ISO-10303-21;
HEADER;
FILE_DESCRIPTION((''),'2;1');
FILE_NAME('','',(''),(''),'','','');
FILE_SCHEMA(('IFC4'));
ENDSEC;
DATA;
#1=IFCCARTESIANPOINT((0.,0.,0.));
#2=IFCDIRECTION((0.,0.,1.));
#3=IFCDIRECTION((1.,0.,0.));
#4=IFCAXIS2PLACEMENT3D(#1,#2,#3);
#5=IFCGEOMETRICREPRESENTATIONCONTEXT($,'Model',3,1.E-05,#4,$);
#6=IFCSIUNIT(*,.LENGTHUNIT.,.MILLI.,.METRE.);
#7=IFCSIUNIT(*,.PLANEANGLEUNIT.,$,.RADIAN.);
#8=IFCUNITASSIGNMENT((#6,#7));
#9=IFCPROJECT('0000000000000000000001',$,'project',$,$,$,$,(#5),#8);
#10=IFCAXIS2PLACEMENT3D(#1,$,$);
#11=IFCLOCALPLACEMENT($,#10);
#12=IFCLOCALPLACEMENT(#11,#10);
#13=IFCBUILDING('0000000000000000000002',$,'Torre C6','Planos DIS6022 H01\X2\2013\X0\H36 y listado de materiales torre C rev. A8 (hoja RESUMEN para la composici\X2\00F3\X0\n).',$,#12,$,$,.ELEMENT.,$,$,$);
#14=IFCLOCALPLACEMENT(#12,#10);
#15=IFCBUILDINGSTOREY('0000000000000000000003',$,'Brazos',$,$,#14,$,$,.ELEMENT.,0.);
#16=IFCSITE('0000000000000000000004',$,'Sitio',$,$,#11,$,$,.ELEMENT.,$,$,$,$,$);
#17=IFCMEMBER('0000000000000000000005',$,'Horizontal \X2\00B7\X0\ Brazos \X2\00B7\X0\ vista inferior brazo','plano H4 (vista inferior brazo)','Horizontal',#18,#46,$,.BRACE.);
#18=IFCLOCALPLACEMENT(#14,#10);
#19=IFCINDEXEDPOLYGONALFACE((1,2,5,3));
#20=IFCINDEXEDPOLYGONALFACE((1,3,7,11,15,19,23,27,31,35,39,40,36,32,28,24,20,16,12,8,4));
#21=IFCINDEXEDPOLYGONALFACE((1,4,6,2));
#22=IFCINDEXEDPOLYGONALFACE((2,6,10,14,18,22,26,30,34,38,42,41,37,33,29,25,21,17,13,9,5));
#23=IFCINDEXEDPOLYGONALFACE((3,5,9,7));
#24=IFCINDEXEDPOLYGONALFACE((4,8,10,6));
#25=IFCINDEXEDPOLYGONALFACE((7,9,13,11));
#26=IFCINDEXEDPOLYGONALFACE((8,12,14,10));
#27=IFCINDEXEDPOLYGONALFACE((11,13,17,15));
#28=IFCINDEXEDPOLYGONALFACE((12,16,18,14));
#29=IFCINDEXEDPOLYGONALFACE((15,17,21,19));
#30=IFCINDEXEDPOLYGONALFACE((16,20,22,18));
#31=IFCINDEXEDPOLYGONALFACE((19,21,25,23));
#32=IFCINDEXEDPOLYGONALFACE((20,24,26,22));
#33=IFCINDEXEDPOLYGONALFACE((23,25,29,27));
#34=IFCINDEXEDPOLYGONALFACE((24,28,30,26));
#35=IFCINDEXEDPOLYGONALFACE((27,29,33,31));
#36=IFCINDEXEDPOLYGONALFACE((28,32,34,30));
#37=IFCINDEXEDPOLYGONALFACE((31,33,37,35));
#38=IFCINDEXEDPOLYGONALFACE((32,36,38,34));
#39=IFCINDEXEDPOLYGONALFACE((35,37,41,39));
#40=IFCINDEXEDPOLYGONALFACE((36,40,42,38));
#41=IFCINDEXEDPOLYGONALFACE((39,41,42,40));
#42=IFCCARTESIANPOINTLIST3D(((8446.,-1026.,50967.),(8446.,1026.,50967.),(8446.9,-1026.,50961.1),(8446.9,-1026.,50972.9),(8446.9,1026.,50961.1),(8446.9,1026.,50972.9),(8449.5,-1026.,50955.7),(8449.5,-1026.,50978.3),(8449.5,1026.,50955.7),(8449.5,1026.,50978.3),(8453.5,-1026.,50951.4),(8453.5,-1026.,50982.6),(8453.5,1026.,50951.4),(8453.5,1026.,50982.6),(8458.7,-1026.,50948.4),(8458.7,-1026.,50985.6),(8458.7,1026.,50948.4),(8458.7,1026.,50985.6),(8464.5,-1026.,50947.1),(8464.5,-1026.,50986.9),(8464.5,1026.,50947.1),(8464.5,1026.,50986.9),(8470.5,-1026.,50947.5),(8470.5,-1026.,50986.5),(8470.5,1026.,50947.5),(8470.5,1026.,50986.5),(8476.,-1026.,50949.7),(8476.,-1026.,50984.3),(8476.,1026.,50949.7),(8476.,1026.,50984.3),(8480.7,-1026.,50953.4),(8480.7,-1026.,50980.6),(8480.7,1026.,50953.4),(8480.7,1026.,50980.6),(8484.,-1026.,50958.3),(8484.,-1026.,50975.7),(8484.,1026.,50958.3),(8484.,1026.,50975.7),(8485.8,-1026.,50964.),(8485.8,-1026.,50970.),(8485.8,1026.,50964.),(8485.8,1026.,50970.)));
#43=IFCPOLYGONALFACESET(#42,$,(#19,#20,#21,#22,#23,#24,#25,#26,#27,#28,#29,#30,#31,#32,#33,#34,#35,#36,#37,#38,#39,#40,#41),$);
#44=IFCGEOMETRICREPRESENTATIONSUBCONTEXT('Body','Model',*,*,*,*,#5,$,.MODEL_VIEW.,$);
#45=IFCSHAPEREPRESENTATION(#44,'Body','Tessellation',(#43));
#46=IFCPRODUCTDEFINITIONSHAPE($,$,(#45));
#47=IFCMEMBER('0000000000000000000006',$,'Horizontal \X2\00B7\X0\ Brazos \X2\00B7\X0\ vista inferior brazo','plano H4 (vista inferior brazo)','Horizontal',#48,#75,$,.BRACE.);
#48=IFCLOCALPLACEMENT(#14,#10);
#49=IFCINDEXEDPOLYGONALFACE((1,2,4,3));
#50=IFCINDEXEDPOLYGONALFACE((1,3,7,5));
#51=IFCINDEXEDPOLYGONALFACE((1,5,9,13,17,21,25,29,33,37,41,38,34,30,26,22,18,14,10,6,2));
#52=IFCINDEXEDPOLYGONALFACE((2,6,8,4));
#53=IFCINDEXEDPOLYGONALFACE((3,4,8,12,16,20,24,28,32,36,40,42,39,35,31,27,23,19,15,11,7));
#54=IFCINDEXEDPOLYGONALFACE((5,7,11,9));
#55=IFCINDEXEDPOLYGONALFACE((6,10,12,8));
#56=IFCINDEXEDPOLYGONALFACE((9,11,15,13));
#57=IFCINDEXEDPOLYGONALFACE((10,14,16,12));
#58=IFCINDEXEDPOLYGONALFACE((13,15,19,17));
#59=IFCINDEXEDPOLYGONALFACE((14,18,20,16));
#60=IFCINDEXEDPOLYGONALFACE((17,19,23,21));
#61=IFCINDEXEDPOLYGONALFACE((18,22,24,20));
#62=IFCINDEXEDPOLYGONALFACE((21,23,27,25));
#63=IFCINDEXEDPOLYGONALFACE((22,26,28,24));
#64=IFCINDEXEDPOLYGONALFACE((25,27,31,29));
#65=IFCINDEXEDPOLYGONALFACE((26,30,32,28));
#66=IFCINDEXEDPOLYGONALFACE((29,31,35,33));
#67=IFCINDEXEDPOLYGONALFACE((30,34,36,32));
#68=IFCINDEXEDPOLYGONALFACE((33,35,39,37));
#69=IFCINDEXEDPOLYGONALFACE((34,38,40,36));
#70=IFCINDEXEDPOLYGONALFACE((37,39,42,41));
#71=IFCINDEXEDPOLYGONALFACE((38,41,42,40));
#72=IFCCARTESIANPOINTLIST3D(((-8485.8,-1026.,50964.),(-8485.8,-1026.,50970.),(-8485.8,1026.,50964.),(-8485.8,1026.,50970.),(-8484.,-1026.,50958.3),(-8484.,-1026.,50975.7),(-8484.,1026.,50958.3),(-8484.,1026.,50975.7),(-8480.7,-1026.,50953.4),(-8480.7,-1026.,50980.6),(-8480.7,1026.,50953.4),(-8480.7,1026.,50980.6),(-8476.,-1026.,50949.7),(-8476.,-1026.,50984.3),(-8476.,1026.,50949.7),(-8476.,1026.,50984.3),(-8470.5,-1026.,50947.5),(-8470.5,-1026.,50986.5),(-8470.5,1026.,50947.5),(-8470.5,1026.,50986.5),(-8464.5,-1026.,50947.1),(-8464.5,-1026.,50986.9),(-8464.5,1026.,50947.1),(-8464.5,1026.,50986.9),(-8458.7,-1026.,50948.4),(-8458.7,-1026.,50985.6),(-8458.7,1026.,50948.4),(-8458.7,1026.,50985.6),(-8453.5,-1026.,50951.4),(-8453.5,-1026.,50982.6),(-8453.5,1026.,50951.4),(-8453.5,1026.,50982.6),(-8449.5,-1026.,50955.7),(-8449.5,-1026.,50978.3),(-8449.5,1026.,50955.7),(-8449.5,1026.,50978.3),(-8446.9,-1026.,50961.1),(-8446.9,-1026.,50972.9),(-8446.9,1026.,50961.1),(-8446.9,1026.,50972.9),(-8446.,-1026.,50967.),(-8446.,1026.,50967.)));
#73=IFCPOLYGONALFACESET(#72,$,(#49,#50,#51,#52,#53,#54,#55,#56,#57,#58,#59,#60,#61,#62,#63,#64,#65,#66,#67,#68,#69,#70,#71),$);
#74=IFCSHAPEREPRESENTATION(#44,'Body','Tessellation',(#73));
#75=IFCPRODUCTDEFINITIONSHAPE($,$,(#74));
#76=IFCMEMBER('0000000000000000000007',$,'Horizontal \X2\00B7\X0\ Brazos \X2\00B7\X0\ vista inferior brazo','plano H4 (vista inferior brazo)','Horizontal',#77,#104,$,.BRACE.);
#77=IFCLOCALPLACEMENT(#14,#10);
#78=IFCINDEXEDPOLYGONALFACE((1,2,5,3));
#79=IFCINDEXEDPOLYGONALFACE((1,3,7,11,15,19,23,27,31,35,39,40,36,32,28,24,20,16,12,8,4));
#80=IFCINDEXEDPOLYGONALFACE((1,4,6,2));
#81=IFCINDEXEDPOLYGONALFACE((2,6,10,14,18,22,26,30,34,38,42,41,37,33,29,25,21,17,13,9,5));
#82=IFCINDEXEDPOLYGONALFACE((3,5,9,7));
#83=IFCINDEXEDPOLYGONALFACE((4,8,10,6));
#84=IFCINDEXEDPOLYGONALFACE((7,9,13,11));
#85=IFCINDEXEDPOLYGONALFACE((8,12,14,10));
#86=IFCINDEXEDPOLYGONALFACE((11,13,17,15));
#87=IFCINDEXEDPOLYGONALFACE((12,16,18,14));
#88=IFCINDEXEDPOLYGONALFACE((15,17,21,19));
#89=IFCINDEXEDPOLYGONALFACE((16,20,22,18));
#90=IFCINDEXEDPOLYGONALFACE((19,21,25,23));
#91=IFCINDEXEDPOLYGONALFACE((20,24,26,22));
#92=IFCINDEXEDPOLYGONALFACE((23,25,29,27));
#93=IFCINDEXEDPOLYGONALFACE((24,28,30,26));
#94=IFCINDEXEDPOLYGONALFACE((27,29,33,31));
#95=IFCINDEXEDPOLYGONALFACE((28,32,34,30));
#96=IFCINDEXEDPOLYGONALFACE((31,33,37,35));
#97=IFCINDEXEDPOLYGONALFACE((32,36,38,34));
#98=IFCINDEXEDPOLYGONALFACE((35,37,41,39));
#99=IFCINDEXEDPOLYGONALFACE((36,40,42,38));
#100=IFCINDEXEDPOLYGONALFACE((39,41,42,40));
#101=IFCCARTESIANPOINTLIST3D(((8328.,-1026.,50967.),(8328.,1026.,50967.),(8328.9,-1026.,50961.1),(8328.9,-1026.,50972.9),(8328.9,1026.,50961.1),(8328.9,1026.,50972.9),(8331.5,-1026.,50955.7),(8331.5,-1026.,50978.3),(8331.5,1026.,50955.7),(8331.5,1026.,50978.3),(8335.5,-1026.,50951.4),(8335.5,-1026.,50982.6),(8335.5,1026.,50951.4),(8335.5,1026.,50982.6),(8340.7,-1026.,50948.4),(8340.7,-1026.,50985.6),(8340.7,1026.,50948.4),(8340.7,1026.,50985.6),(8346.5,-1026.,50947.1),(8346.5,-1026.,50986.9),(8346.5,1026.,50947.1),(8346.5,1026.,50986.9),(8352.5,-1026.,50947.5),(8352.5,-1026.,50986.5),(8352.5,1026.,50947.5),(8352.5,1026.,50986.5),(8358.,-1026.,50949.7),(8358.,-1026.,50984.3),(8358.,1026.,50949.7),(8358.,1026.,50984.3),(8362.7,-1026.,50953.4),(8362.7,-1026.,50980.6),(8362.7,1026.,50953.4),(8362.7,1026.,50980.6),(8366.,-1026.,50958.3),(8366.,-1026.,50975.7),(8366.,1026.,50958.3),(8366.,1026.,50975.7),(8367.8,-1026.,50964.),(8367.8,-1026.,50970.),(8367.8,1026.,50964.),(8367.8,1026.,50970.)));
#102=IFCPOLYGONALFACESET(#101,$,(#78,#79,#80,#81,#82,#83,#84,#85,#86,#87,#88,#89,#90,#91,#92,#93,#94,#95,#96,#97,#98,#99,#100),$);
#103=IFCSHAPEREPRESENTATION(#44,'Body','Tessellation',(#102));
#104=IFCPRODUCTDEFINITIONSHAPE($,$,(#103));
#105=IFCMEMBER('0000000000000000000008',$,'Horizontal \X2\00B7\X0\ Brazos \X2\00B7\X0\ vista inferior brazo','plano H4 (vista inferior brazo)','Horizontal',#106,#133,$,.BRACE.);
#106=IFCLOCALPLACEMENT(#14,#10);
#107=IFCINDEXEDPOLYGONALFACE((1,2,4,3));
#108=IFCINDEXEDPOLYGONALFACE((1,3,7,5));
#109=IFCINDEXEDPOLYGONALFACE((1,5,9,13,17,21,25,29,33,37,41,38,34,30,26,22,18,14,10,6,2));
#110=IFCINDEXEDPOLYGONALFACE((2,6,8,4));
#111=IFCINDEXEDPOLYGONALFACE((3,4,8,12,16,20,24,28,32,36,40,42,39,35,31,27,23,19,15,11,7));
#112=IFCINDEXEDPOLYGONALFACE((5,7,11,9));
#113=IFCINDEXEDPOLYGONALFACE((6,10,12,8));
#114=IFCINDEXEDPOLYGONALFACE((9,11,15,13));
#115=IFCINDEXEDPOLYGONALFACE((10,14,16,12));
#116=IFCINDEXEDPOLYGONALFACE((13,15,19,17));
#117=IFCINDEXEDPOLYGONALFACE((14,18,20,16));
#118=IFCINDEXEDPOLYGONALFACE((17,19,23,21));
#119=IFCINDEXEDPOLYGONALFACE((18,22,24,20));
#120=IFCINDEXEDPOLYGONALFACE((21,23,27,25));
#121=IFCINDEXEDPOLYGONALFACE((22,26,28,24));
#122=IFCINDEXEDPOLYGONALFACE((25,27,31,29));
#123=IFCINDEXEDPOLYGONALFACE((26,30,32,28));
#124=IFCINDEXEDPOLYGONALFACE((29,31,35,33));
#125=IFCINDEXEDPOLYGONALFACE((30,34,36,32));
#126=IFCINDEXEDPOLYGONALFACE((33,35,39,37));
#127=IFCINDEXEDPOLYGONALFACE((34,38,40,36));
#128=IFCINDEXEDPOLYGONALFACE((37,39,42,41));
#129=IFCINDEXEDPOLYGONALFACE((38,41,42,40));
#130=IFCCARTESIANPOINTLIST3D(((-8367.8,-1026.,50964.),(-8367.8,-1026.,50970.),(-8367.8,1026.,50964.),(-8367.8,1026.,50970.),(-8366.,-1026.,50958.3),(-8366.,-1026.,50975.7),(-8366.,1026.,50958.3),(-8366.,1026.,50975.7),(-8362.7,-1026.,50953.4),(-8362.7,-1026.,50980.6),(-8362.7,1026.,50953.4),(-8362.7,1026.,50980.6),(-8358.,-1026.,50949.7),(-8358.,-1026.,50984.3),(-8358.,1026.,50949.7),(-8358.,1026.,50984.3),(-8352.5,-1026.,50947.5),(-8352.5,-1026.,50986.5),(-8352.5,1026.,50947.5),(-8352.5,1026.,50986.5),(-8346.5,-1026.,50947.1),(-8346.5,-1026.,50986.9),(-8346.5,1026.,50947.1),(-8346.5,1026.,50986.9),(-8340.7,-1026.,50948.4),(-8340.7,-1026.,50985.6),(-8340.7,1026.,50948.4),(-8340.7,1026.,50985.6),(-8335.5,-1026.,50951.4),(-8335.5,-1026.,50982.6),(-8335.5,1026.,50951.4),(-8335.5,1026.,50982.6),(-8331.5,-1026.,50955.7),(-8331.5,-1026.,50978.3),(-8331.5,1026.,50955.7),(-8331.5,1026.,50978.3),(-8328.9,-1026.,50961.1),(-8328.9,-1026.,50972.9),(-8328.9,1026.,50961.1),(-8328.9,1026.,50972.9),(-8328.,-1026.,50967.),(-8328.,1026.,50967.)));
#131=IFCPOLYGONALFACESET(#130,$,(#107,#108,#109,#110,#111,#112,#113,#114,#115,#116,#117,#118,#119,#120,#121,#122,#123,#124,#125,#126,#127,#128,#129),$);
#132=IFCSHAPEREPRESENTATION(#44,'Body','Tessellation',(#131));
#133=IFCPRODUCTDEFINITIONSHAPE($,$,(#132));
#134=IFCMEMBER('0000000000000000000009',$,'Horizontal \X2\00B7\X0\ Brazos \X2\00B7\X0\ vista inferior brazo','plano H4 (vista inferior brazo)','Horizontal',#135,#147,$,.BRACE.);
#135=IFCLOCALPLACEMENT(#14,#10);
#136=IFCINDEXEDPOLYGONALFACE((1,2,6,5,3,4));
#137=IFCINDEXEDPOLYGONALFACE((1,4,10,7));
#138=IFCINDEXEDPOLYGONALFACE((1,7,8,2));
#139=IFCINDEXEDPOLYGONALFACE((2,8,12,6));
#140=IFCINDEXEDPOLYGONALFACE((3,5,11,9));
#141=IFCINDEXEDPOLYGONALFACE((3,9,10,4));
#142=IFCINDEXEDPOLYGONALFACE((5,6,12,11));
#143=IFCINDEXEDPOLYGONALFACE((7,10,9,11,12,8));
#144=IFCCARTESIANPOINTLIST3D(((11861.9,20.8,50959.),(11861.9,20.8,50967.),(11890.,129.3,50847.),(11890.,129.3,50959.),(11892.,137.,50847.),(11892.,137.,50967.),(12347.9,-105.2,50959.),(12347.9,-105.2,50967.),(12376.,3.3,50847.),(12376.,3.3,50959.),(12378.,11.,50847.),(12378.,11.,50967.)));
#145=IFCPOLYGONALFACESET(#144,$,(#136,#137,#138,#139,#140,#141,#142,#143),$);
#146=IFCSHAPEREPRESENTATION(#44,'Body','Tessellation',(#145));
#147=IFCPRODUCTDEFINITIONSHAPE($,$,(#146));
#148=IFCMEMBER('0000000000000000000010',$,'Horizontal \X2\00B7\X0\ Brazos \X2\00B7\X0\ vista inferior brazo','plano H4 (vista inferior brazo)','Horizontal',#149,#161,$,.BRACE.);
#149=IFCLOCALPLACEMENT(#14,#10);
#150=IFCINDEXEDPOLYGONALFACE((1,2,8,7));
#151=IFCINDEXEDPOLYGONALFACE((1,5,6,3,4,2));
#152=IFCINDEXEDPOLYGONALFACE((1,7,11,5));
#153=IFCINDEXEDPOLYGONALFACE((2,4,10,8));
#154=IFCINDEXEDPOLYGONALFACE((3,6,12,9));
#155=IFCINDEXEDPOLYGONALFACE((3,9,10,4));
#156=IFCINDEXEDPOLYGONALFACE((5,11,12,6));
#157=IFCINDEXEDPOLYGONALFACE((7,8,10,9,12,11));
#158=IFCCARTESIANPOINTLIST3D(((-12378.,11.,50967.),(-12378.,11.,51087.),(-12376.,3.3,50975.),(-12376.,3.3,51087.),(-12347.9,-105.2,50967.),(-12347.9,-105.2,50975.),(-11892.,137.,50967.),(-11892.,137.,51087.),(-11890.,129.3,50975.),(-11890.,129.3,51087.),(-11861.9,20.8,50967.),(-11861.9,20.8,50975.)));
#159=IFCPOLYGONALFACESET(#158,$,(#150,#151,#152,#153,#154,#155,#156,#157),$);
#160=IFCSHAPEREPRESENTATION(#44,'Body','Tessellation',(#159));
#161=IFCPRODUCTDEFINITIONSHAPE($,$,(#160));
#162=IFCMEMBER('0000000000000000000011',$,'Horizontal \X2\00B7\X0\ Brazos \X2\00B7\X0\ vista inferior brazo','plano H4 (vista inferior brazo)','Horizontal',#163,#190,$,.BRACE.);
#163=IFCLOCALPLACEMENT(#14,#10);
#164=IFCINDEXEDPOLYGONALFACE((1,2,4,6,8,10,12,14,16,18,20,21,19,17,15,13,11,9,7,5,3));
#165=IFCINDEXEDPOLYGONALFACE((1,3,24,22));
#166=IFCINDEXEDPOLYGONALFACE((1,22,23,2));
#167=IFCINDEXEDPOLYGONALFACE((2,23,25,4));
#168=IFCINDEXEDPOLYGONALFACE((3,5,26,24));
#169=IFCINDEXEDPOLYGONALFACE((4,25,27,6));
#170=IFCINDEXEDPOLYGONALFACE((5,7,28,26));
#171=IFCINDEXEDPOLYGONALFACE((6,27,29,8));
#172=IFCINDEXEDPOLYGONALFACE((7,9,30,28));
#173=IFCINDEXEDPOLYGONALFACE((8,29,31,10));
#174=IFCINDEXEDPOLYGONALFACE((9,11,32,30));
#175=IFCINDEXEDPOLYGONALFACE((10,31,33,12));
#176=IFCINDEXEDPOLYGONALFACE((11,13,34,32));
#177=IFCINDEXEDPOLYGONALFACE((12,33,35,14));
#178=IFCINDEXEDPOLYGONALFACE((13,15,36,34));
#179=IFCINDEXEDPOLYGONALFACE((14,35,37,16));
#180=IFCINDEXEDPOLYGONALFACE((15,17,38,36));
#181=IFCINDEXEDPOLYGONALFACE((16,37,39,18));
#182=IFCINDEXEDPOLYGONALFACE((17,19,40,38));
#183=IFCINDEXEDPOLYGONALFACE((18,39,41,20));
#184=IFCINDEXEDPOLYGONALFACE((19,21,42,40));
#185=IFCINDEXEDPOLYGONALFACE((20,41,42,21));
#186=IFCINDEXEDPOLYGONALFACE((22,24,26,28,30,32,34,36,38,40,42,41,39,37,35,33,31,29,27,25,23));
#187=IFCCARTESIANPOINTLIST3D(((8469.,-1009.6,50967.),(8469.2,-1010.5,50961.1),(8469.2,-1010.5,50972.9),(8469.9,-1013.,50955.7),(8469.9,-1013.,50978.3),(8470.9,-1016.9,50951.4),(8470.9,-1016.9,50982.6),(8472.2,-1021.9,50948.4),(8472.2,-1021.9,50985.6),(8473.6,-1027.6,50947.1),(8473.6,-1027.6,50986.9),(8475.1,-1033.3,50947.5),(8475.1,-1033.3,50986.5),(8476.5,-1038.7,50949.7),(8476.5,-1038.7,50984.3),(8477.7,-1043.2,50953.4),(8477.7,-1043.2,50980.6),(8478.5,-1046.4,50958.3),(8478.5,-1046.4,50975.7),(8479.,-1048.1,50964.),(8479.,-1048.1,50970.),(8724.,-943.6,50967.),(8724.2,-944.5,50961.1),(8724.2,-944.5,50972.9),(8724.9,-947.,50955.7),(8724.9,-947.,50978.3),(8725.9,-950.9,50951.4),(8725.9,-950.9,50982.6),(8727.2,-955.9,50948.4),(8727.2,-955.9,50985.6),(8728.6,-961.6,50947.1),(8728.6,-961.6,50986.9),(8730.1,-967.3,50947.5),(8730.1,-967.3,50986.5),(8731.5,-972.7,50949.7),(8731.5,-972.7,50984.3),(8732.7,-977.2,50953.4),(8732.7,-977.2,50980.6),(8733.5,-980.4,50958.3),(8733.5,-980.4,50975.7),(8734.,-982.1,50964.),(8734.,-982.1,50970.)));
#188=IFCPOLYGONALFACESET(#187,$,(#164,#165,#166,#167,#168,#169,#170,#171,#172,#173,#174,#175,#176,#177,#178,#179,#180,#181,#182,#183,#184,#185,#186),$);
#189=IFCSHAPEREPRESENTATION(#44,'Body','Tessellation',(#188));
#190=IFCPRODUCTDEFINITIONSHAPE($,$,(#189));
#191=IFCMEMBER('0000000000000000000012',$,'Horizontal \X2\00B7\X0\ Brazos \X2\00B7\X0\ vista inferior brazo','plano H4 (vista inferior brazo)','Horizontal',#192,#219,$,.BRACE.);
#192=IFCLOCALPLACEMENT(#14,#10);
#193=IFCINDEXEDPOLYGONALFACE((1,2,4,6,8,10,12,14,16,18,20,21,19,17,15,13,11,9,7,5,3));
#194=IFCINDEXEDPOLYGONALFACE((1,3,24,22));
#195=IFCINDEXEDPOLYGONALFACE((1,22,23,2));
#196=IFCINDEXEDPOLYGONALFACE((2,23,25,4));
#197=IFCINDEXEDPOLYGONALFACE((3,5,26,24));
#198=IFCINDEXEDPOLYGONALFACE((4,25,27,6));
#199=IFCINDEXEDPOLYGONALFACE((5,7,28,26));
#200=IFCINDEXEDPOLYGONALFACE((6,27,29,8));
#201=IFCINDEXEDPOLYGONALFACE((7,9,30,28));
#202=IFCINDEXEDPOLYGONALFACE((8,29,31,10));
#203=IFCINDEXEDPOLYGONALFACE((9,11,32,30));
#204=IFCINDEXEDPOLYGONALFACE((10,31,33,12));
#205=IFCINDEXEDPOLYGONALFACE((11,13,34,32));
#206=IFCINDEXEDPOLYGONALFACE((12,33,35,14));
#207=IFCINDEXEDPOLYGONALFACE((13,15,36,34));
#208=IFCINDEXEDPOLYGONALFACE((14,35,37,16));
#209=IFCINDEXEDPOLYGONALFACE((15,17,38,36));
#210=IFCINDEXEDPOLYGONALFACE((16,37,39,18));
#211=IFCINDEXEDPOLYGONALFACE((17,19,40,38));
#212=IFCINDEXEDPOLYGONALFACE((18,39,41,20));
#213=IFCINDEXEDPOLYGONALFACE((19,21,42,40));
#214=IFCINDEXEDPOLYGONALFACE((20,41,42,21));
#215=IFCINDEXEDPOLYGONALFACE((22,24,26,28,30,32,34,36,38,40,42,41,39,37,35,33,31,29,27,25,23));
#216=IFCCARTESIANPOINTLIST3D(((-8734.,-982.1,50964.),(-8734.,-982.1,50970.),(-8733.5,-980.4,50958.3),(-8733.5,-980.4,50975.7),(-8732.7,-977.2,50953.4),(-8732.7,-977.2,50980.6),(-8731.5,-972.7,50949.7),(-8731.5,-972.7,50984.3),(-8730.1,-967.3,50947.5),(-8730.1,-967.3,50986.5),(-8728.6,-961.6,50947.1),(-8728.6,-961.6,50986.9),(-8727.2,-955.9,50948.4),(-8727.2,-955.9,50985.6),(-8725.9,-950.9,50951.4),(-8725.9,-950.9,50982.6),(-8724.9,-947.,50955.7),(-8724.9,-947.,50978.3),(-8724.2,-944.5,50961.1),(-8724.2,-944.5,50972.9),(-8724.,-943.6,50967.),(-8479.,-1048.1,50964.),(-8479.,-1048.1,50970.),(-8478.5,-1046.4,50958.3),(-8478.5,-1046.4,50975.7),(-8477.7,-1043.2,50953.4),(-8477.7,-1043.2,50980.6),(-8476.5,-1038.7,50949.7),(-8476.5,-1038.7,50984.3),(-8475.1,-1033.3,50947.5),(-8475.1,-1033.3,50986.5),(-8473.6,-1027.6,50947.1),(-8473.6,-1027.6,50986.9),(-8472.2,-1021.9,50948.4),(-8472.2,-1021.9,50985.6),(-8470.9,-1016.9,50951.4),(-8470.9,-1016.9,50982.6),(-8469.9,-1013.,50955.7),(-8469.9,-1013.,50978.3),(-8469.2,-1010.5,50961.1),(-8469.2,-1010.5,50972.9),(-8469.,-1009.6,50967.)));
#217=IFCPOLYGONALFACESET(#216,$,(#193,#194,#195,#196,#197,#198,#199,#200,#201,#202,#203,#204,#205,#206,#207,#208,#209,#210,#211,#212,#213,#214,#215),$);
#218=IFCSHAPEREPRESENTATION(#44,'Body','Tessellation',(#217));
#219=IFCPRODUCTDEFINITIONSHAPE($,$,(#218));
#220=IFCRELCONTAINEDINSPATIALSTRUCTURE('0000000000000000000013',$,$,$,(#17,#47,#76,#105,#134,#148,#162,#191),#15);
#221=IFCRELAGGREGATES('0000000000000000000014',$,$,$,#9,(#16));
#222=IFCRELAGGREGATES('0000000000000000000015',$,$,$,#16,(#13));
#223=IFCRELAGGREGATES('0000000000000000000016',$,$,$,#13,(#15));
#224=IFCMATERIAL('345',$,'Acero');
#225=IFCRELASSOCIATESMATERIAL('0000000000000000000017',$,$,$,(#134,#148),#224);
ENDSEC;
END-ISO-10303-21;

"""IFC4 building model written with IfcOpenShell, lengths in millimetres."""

from ifc_helpers import new_model, si_unit, frame, frame_2d, origin, origin_with_axes, place, context, subcontext, project, spatial, circle, l_section, extrude, material, element, save


model = new_model("IFC4")

# Units and contexts
model_context = context("Model", 3, precision=1e-05, world=origin_with_axes())
body_context = subcontext(model_context, "Body", "Model", "MODEL_VIEW")
ifc_project = project(units=[si_unit("LENGTHUNIT", "METRE", prefix="MILLI"), si_unit("PLANEANGLEUNIT", "RADIAN")], contexts=[model_context])

# Site, building, storey
site_placement = place(None, origin())
site = spatial("IfcSite", under=ifc_project, at=site_placement, Name="Sitio", CompositionType="ELEMENT")
building_placement = place(site_placement, origin())
building = spatial("IfcBuilding", under=site, at=building_placement, Name="Torre C6", Description="Planos DIS6022 H01–H36 y listado de materiales torre C rev. A8 (hoja RESUMEN para la composición).", CompositionType="ELEMENT")
storey_placement = place(building_placement, origin())
storey = spatial("IfcBuildingStorey", under=building, at=storey_placement, Name="Brazos", CompositionType="ELEMENT", Elevation=0.0)

# Members
ifc_material_1 = material(Name="345", Category="Acero")
for number, where, z_axis, x_axis, name in (
    (1, (8466.0, -1026.0, 50967.0), (0.0, 1.0, 0.0), (-1.0, 0.0, 0.0), "Horizontal · Brazos · vista inferior brazo"),
    (2, (-8466.0, -1026.0, 50967.0), (0.0, 1.0, 0.0), (1.0, 0.0, 0.0), "Horizontal · Brazos · vista inferior brazo"),
    (3, (8348.0, -1026.0, 50967.0), (0.0, 1.0, 0.0), (-1.0, 0.0, 0.0), "Horizontal · Brazos · vista inferior brazo"),
    (4, (-8348.0, -1026.0, 50967.0), (0.0, 1.0, 0.0), (1.0, 0.0, 0.0), "Horizontal · Brazos · vista inferior brazo"),
):
    element("IfcMember", number, at=place(storey_placement, frame(where, z_axis=z_axis, x_axis=x_axis)), inside=storey, Name=name, Description="plano H4 (vista inferior brazo)", ObjectType="Horizontal", PredefinedType="BRACE", context=body_context, shape_type="SweptSolid", body=[
        extrude(circle(Radius=20.0), None, (0.0, 0.0, 1.0), 2052.0),
    ])
for number, where, z_axis, x_axis, name in (
    (5, (11892.0, 137.0, 50967.0), (0.967997, -0.250962, 0.0), (-0.250962, -0.967997, 0.0), "Horizontal · Brazos · vista inferior brazo"),
    (6, (-11892.0, 137.0, 50967.0), (-0.967997, -0.250962, 0.0), (0.250962, -0.967997, 0.0), "Horizontal · Brazos · vista inferior brazo"),
):
    element("IfcMember", number, at=place(storey_placement, frame(where, z_axis=z_axis, x_axis=x_axis)), inside=storey, material=ifc_material_1, Name=name, Description="plano H4 (vista inferior brazo)", ObjectType="Horizontal", PredefinedType="BRACE", context=body_context, shape_type="SweptSolid", body=[
        extrude(l_section(Depth=120.0, Width=120.0, Thickness=8.0, at=frame_2d((60.0, 60.0))), None, (0.0, 0.0, 1.0), 502.1),
    ])
for number, where, z_axis, x_axis, name in (
    (7, (8474.0, -1029.0, 50967.0), (0.968099, 0.250567, 0.0), (-0.250567, 0.968099, 0.0), "Horizontal · Brazos · vista inferior brazo"),
    (8, (-8474.0, -1029.0, 50967.0), (-0.968099, 0.250567, 0.0), (0.250567, 0.968099, 0.0), "Horizontal · Brazos · vista inferior brazo"),
):
    element("IfcMember", number, at=place(storey_placement, frame(where, z_axis=z_axis, x_axis=x_axis)), inside=storey, Name=name, Description="plano H4 (vista inferior brazo)", ObjectType="Horizontal", PredefinedType="BRACE", context=body_context, shape_type="SweptSolid", body=[
        extrude(circle(Radius=20.0), None, (0.0, 0.0, 1.0), 263.4),
    ])

save(model, "model.ifc")
